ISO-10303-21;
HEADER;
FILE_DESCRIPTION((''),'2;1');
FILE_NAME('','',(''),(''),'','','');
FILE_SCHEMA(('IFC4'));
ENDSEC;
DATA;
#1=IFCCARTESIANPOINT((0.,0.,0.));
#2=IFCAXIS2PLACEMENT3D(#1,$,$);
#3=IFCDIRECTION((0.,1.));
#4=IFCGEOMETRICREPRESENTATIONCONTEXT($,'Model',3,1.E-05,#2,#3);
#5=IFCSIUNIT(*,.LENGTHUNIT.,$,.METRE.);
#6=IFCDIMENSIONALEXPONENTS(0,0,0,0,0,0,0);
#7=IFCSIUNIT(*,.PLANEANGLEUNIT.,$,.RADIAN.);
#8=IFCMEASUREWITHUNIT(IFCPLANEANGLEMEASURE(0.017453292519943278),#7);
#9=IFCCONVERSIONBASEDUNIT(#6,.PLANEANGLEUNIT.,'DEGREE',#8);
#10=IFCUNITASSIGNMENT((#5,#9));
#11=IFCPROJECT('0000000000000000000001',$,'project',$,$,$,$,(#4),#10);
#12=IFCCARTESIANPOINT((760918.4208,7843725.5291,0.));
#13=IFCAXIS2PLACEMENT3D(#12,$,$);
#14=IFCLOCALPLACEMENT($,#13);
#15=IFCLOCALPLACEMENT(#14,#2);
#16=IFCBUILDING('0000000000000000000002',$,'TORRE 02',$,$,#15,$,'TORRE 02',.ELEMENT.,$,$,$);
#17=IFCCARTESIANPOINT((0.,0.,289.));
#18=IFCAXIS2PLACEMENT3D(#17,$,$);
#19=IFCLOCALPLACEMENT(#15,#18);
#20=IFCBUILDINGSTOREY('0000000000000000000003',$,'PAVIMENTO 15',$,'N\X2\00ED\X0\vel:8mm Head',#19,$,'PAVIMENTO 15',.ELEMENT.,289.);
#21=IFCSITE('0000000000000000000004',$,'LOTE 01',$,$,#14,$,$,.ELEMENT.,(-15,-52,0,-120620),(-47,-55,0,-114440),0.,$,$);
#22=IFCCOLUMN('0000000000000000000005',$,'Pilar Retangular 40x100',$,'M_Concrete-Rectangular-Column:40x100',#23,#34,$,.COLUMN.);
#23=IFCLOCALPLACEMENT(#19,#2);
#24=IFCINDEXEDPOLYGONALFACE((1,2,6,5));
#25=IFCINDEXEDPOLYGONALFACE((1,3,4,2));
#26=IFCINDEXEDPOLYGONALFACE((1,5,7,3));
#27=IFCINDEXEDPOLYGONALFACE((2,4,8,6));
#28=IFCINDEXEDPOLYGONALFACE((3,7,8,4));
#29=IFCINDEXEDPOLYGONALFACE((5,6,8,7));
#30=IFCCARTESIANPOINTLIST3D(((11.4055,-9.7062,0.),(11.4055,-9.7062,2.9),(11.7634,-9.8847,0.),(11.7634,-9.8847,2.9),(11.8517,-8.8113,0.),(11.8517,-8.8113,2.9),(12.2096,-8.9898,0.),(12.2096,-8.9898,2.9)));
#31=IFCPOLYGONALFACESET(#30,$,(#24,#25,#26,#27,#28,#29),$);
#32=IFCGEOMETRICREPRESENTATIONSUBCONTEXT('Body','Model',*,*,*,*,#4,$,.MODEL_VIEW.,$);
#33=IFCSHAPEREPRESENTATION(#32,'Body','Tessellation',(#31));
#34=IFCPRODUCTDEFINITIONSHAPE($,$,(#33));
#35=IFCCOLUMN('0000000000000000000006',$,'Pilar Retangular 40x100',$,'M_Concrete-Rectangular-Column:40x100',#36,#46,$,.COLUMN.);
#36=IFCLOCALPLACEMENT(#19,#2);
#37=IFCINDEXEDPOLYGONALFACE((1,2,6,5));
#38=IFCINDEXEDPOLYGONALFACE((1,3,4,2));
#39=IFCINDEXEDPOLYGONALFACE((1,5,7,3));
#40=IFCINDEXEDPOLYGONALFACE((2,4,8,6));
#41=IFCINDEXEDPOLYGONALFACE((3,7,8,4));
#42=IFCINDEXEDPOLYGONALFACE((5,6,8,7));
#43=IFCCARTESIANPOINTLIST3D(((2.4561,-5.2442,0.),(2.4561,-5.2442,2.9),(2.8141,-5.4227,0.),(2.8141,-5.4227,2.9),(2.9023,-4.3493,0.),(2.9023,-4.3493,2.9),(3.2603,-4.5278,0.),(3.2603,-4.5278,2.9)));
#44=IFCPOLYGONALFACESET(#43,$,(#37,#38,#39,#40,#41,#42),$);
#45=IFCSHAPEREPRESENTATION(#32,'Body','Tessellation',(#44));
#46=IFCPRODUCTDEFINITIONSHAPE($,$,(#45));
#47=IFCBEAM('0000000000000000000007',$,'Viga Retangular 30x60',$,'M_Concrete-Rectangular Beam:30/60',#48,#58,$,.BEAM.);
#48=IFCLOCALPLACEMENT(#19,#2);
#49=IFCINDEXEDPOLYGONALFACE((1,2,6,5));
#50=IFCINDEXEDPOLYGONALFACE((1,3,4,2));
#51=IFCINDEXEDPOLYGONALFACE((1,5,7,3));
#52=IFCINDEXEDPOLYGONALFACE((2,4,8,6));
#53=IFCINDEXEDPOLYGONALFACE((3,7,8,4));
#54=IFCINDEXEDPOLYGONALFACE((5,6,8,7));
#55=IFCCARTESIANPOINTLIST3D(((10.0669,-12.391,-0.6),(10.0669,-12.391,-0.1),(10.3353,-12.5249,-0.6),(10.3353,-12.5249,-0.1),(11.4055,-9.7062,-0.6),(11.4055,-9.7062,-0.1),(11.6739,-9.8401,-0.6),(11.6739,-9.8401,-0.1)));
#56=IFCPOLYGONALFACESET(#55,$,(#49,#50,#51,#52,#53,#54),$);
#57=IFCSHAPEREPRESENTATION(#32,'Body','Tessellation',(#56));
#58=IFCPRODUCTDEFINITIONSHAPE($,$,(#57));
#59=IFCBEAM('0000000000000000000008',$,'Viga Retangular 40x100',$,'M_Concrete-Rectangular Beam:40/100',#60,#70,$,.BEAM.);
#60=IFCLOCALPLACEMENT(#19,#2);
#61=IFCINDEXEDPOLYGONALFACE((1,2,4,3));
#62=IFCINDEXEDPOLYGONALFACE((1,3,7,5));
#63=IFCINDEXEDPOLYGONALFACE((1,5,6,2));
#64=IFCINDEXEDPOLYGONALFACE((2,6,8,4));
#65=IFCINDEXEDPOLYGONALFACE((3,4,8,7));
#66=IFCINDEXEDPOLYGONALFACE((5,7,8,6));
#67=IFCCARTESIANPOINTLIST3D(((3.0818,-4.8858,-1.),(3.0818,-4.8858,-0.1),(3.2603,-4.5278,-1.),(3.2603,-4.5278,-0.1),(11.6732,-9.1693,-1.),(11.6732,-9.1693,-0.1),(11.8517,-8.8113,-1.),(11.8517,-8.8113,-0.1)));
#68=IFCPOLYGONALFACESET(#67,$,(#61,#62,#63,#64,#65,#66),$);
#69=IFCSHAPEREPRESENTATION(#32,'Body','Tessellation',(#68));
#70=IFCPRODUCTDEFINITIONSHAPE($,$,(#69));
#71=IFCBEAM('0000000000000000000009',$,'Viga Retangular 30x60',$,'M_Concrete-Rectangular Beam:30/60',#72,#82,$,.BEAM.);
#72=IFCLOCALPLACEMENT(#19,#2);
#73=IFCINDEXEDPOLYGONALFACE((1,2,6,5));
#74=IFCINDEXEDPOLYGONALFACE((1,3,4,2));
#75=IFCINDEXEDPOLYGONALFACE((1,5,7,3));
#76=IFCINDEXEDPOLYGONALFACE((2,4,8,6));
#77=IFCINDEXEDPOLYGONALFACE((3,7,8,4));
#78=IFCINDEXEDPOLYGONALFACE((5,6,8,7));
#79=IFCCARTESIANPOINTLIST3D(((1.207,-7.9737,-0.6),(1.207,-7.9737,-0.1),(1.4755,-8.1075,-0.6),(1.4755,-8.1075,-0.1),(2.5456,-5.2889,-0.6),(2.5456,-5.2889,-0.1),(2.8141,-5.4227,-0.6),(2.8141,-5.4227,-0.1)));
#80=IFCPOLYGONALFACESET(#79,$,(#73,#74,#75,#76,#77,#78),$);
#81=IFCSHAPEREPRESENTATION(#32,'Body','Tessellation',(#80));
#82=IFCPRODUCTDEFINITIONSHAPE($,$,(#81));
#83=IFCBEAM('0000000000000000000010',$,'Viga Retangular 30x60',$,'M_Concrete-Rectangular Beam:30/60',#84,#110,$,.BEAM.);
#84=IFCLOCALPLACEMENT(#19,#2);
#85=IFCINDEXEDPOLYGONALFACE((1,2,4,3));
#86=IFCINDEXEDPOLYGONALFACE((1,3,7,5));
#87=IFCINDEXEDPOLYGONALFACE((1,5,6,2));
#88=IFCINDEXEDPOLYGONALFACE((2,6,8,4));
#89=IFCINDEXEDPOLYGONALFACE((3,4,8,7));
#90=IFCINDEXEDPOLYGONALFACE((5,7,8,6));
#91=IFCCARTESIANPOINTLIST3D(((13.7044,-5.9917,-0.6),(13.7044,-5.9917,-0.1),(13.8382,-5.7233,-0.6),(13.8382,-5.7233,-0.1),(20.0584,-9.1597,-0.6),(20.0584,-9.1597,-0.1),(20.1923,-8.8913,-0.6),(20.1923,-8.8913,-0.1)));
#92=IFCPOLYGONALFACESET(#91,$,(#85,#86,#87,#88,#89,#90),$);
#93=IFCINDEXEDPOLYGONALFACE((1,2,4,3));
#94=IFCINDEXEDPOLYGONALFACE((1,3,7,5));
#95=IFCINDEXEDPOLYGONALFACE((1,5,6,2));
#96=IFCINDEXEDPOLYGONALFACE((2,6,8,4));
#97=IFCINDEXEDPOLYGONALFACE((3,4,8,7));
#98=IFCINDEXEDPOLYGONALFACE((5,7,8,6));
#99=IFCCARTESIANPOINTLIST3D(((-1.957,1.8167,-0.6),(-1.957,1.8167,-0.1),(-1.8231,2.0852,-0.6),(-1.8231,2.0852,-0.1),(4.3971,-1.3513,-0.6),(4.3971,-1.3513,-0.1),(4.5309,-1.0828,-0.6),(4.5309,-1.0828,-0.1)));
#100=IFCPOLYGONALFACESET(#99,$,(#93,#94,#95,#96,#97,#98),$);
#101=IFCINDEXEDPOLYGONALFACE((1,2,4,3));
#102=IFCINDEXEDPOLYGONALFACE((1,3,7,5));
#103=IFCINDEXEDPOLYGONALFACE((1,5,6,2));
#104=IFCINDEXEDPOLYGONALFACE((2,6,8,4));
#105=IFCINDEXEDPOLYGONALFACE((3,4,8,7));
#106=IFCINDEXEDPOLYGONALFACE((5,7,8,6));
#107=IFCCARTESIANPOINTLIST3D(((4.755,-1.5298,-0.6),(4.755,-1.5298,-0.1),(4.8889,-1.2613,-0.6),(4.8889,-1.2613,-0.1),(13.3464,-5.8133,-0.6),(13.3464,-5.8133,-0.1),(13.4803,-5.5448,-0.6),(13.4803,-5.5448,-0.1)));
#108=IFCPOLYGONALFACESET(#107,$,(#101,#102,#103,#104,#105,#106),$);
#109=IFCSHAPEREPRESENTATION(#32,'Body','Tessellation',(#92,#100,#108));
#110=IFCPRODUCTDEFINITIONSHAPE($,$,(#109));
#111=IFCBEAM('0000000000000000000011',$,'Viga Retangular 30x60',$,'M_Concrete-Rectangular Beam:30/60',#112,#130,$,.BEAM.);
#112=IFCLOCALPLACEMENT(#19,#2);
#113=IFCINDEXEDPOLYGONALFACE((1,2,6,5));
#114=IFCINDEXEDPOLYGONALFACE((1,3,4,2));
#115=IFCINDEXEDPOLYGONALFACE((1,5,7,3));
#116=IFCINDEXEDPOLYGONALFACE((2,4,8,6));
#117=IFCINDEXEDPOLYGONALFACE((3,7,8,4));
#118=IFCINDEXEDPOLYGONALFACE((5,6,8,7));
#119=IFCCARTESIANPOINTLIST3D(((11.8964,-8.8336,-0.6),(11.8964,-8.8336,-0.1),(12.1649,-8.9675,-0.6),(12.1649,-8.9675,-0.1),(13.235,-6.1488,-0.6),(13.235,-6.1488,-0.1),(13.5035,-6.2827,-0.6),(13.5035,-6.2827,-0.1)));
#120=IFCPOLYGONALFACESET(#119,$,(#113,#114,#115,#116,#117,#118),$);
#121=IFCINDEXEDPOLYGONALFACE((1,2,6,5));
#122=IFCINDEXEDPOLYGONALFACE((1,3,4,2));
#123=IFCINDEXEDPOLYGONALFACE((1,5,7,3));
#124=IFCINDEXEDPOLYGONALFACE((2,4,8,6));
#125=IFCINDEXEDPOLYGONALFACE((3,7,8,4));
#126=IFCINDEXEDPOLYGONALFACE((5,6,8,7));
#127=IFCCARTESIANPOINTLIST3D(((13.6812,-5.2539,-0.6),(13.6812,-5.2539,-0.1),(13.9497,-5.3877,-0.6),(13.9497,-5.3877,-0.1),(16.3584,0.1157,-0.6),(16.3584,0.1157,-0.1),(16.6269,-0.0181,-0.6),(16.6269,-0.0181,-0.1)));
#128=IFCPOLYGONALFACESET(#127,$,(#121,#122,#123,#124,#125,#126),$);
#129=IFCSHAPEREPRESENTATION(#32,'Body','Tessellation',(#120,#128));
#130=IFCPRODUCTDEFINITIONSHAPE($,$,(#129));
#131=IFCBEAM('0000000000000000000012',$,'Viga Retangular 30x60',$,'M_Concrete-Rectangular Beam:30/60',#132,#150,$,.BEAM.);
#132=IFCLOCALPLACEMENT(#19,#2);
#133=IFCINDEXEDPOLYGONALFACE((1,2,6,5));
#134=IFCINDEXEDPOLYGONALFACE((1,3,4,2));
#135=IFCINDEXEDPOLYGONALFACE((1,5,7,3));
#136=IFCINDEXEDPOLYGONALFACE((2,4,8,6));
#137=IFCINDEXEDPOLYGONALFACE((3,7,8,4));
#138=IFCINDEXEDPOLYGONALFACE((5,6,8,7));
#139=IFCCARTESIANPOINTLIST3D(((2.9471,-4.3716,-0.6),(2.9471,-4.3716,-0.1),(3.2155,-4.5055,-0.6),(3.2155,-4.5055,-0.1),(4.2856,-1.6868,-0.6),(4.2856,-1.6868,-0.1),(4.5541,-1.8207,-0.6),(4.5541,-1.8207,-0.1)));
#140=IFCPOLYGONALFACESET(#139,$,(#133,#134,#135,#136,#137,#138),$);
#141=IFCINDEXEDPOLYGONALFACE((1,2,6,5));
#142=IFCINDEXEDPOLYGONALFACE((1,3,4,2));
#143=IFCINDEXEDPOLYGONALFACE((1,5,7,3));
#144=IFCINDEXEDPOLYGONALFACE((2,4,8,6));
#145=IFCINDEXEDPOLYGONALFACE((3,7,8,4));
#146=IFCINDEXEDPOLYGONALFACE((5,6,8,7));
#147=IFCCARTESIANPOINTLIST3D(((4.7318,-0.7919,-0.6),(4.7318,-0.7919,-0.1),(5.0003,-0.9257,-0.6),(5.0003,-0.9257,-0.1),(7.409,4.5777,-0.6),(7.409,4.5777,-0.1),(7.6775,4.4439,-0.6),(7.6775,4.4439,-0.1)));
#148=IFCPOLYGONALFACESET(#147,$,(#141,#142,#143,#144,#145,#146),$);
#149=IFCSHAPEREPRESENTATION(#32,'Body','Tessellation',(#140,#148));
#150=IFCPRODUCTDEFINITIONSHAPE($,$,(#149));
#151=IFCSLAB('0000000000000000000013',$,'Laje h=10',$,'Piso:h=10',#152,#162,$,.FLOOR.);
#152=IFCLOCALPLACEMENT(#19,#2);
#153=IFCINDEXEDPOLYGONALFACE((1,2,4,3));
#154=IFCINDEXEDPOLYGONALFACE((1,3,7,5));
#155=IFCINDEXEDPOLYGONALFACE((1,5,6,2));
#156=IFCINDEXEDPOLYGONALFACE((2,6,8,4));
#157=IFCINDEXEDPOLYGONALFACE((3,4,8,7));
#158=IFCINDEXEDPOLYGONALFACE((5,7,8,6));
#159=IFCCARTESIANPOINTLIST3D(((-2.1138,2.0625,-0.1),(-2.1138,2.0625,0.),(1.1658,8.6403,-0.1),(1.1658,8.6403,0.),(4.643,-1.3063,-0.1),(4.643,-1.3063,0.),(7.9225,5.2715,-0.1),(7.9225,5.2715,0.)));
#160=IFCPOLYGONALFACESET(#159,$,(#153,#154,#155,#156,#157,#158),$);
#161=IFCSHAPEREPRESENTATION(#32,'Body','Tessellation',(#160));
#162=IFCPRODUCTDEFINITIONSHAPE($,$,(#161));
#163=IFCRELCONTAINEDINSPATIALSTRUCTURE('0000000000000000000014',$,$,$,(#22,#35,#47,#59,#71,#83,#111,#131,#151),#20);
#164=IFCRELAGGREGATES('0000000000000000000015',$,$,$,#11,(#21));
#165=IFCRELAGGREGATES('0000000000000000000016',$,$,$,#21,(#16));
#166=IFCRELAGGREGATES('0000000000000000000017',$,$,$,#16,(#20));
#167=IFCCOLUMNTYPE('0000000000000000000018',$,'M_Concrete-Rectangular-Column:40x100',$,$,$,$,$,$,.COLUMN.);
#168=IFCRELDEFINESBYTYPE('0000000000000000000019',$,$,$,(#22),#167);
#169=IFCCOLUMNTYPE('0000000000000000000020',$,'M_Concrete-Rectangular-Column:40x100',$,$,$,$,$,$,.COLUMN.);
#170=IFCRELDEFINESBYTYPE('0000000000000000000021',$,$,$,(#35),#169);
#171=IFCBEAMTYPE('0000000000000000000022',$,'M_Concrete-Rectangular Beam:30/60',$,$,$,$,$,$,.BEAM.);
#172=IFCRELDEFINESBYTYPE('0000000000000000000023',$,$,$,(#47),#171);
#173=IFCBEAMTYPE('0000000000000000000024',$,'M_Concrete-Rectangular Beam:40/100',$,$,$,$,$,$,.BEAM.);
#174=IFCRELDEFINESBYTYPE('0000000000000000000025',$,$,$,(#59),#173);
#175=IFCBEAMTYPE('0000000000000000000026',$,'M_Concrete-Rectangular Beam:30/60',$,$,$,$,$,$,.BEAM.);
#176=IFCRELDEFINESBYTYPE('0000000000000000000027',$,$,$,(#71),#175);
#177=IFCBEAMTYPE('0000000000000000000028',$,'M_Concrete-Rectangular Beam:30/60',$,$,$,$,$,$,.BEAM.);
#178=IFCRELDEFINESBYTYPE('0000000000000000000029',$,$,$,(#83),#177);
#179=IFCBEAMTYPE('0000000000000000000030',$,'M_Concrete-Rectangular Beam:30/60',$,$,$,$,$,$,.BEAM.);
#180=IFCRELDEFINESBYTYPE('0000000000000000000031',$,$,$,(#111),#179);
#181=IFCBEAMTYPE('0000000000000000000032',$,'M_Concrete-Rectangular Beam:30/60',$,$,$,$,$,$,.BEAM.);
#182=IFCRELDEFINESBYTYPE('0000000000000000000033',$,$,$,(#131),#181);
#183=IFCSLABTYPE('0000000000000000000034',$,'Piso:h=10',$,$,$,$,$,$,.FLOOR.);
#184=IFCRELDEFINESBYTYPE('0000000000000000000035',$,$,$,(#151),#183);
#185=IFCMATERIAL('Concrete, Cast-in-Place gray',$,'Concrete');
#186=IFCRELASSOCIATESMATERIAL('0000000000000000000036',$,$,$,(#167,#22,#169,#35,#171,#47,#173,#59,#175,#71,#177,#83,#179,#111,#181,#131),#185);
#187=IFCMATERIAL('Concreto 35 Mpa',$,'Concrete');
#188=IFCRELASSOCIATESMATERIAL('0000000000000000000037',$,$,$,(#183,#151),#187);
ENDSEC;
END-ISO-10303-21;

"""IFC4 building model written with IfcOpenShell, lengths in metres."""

from ifc_helpers import new_model, entity, si_unit, converted_unit, direction, frame, origin, place, context, subcontext, project, spatial, indexed_curve, outline, extrude, source, transform, mapped, material, type_object, type_shapes, element, save


model = new_model("IFC4")

# Units and contexts
model_context = context("Model", 3, precision=1e-05, world=origin(), true_north=direction((0.0, 1.0)))
body_context = subcontext(model_context, "Body", "Model", "MODEL_VIEW")
ifc_project = project(units=[si_unit("LENGTHUNIT", "METRE"), converted_unit("PLANEANGLEUNIT", "DEGREE", entity("IfcPlaneAngleMeasure", 0.017453292519943278), si_unit("PLANEANGLEUNIT", "RADIAN"), dimensions=[0, 0, 0, 0, 0, 0, 0])], contexts=[model_context])

# Site, building, storey
site_placement = place(None, frame((760918.4208, 7843725.5291, 0.0)))
site = spatial("IfcSite", under=ifc_project, at=site_placement, Name="LOTE 01", CompositionType="ELEMENT", RefLatitude=(-15, -52, 0, -120620), RefLongitude=(-47, -55, 0, -114440), RefElevation=0.0)
building_placement = place(site_placement, origin())
building = spatial("IfcBuilding", under=site, at=building_placement, Name="TORRE 02", LongName="TORRE 02", CompositionType="ELEMENT")
storey_placement = place(building_placement, frame((0.0, 0.0, 289.0)))
storey = spatial("IfcBuildingStorey", under=building, at=storey_placement, Name="PAVIMENTO 15", ObjectType="Nível:8mm Head", LongName="PAVIMENTO 15", CompositionType="ELEMENT", Elevation=289.0)

# Columns
ifc_material_1 = material(Name="Concrete, Cast-in-Place gray", Category="Concrete")
column_type_1 = type_object("IfcColumnType", Name="M_Concrete-Rectangular-Column:40x100", PredefinedType="COLUMN", material=ifc_material_1)
shared_shape_1 = source(origin(), body_context, "Body", "SweptSolid", [
    extrude(outline(indexed_curve([(-1.45, -0.2), (1.45, -0.2), (1.45, 0.2), (-1.45, 0.2), (-1.45, -0.2)], self_intersect=False)), frame((11.5844, -9.7955, 290.45), z_axis=(0.446198, 0.894934, 0.0), x_axis=(0.0, 0.0, 1.0)), (0.0, 0.0, 1.0), 1.0),
])
type_shapes(column_type_1, [shared_shape_1])
column_1_placement = place(storey_placement, frame((0.0, 0.0, -289.0)))
element("IfcColumn", 1, at=column_1_placement, inside=storey, type_object=column_type_1, material=ifc_material_1, Name="Pilar Retangular 40x100", ObjectType="M_Concrete-Rectangular-Column:40x100", PredefinedType="COLUMN", context=body_context, shape_type="MappedRepresentation", body=[
    mapped(shared_shape_1, transform((0.0, 0.0, 0.0), scale=1.0)),
])
column_type_2 = type_object("IfcColumnType", Name="M_Concrete-Rectangular-Column:40x100", PredefinedType="COLUMN", material=ifc_material_1)
shared_shape_2 = source(origin(), body_context, "Body", "SweptSolid", [
    extrude(outline(indexed_curve([(-1.45, -0.2), (1.45, -0.2), (1.45, 0.2), (-1.45, 0.2), (-1.45, -0.2)], self_intersect=False)), frame((2.6351, -5.3335, 290.45), z_axis=(0.446198, 0.894934, 0.0), x_axis=(0.0, 0.0, 1.0)), (0.0, 0.0, 1.0), 1.0),
])
type_shapes(column_type_2, [shared_shape_2])
column_2_placement = place(storey_placement, frame((0.0, 0.0, -289.0)))
element("IfcColumn", 2, at=column_2_placement, inside=storey, type_object=column_type_2, material=ifc_material_1, Name="Pilar Retangular 40x100", ObjectType="M_Concrete-Rectangular-Column:40x100", PredefinedType="COLUMN", context=body_context, shape_type="MappedRepresentation", body=[
    mapped(shared_shape_2, transform((0.0, 0.0, 0.0), scale=1.0)),
])

# Beams
beam_type_1 = type_object("IfcBeamType", Name="M_Concrete-Rectangular Beam:30/60", PredefinedType="BEAM", material=ifc_material_1)
shared_shape_3 = source(origin(), body_context, "Body", "SweptSolid", [
    extrude(outline(indexed_curve([(-0.25, -0.15), (0.25, -0.15), (0.25, 0.15), (-0.25, 0.15), (-0.25, -0.15)], self_intersect=False)), frame((10.2011, -12.458, 288.65), z_axis=(0.446198, 0.894934, 0.0), x_axis=(0.0, 0.0, 1.0)), (0.0, 0.0, 1.0), 3.0),
])
type_shapes(beam_type_1, [shared_shape_3])
beam_1_placement = place(storey_placement, frame((0.0, 0.0, -289.0)))
element("IfcBeam", 3, at=beam_1_placement, inside=storey, type_object=beam_type_1, material=ifc_material_1, Name="Viga Retangular 30x60", ObjectType="M_Concrete-Rectangular Beam:30/60", PredefinedType="BEAM", context=body_context, shape_type="MappedRepresentation", body=[
    mapped(shared_shape_3, transform((0.0, 0.0, 0.0), scale=1.0)),
])
beam_type_2 = type_object("IfcBeamType", Name="M_Concrete-Rectangular Beam:40/100", PredefinedType="BEAM", material=ifc_material_1)
shared_shape_4 = source(origin(), body_context, "Body", "SweptSolid", [
    extrude(outline(indexed_curve([(-0.45, -0.2), (0.45, -0.2), (0.45, 0.2), (-0.45, 0.2), (-0.45, -0.2)], self_intersect=False)), frame((11.7624, -8.9903, 288.45), z_axis=(-0.894934, 0.446198, 0.0), x_axis=(0.0, 0.0, 1.0)), (0.0, 0.0, 1.0), 9.6),
])
type_shapes(beam_type_2, [shared_shape_4])
beam_2_placement = place(storey_placement, frame((0.0, 0.0, -289.0)))
element("IfcBeam", 4, at=beam_2_placement, inside=storey, type_object=beam_type_2, material=ifc_material_1, Name="Viga Retangular 40x100", ObjectType="M_Concrete-Rectangular Beam:40/100", PredefinedType="BEAM", context=body_context, shape_type="MappedRepresentation", body=[
    mapped(shared_shape_4, transform((0.0, 0.0, 0.0), scale=1.0)),
])
beam_type_3 = type_object("IfcBeamType", Name="M_Concrete-Rectangular Beam:30/60", PredefinedType="BEAM", material=ifc_material_1)
shared_shape_5 = source(origin(), body_context, "Body", "SweptSolid", [
    extrude(outline(indexed_curve([(-0.25, -0.15), (0.25, -0.15), (0.25, 0.15), (-0.25, 0.15), (-0.25, -0.15)], self_intersect=False)), frame((2.6798, -5.3558, 288.65), z_axis=(-0.446198, -0.894934, 0.0), x_axis=(0.0, 0.0, -1.0)), (0.0, 0.0, 1.0), 3.0),
])
type_shapes(beam_type_3, [shared_shape_5])
beam_3_placement = place(storey_placement, frame((0.0, 0.0, -289.0)))
element("IfcBeam", 5, at=beam_3_placement, inside=storey, type_object=beam_type_3, material=ifc_material_1, Name="Viga Retangular 30x60", ObjectType="M_Concrete-Rectangular Beam:30/60", PredefinedType="BEAM", context=body_context, shape_type="MappedRepresentation", body=[
    mapped(shared_shape_5, transform((0.0, 0.0, 0.0), scale=1.0)),
])
beam_type_4 = type_object("IfcBeamType", Name="M_Concrete-Rectangular Beam:30/60", PredefinedType="BEAM", material=ifc_material_1)
shared_shape_6 = source(origin(), body_context, "Body", "SweptSolid", [
    extrude(outline(indexed_curve([(-0.25, -0.15), (0.25, -0.15), (0.25, 0.15), (-0.25, 0.15), (-0.25, -0.15)], self_intersect=False)), frame((13.7713, -5.8575, 288.65), z_axis=(0.894934, -0.446198, 0.0), x_axis=(0.0, 0.0, -1.0)), (0.0, 0.0, 1.0), 7.1),
    extrude(outline(indexed_curve([(-0.25, -0.15), (0.25, -0.15), (0.25, 0.15), (-0.25, 0.15), (-0.25, -0.15)], self_intersect=False)), frame((-1.89, 1.951, 288.65), z_axis=(0.894934, -0.446198, 0.0), x_axis=(0.0, 0.0, -1.0)), (0.0, 0.0, 1.0), 7.1),
    extrude(outline(indexed_curve([(-0.25, -0.15), (0.25, -0.15), (0.25, 0.15), (-0.25, 0.15), (-0.25, -0.15)], self_intersect=False)), frame((4.822, -1.3955, 288.65), z_axis=(0.894934, -0.446198, 0.0), x_axis=(0.0, 0.0, -1.0)), (0.0, 0.0, 1.0), 9.6),
])
type_shapes(beam_type_4, [shared_shape_6])
beam_4_placement = place(storey_placement, frame((0.0, 0.0, -289.0)))
element("IfcBeam", 6, at=beam_4_placement, inside=storey, type_object=beam_type_4, material=ifc_material_1, Name="Viga Retangular 30x60", ObjectType="M_Concrete-Rectangular Beam:30/60", PredefinedType="BEAM", context=body_context, shape_type="MappedRepresentation", body=[
    mapped(shared_shape_6, transform((0.0, 0.0, 0.0), scale=1.0)),
])
beam_type_5 = type_object("IfcBeamType", Name="M_Concrete-Rectangular Beam:30/60", PredefinedType="BEAM", material=ifc_material_1)
shared_shape_7 = source(origin(), body_context, "Body", "SweptSolid", [
    extrude(outline(indexed_curve([(-0.25, -0.15), (0.25, -0.15), (0.25, 0.15), (-0.25, 0.15), (-0.25, -0.15)], self_intersect=False)), frame((12.0306, -8.9005, 288.65), z_axis=(0.446198, 0.894934, 0.0), x_axis=(0.0, 0.0, 1.0)), (0.0, 0.0, 1.0), 3.0),
    extrude(outline(indexed_curve([(-0.25, -0.15), (0.25, -0.15), (0.25, 0.15), (-0.25, 0.15), (-0.25, -0.15)], self_intersect=False)), frame((13.8154, -5.3208, 288.65), z_axis=(0.446198, 0.894934, 0.0), x_axis=(0.0, 0.0, 1.0)), (0.0, 0.0, 1.0), 6.0),
])
type_shapes(beam_type_5, [shared_shape_7])
beam_5_placement = place(storey_placement, frame((0.0, 0.0, -289.0)))
element("IfcBeam", 7, at=beam_5_placement, inside=storey, type_object=beam_type_5, material=ifc_material_1, Name="Viga Retangular 30x60", ObjectType="M_Concrete-Rectangular Beam:30/60", PredefinedType="BEAM", context=body_context, shape_type="MappedRepresentation", body=[
    mapped(shared_shape_7, transform((0.0, 0.0, 0.0), scale=1.0)),
])
beam_type_6 = type_object("IfcBeamType", Name="M_Concrete-Rectangular Beam:30/60", PredefinedType="BEAM", material=ifc_material_1)
shared_shape_8 = source(origin(), body_context, "Body", "SweptSolid", [
    extrude(outline(indexed_curve([(-0.25, -0.15), (0.25, -0.15), (0.25, 0.15), (-0.25, 0.15), (-0.25, -0.15)], self_intersect=False)), frame((3.0813, -4.4385, 288.65), z_axis=(0.446198, 0.894934, 0.0), x_axis=(0.0, 0.0, 1.0)), (0.0, 0.0, 1.0), 3.0),
    extrude(outline(indexed_curve([(-0.25, -0.15), (0.25, -0.15), (0.25, 0.15), (-0.25, 0.15), (-0.25, -0.15)], self_intersect=False)), frame((4.8661, -0.8588, 288.65), z_axis=(0.446198, 0.894934, 0.0), x_axis=(0.0, 0.0, 1.0)), (0.0, 0.0, 1.0), 6.0),
])
type_shapes(beam_type_6, [shared_shape_8])
beam_6_placement = place(storey_placement, frame((0.0, 0.0, -289.0)))
element("IfcBeam", 8, at=beam_6_placement, inside=storey, type_object=beam_type_6, material=ifc_material_1, Name="Viga Retangular 30x60", ObjectType="M_Concrete-Rectangular Beam:30/60", PredefinedType="BEAM", context=body_context, shape_type="MappedRepresentation", body=[
    mapped(shared_shape_8, transform((0.0, 0.0, 0.0), scale=1.0)),
])

# Slab
ifc_material_2 = material(Name="Concreto 35 Mpa", Category="Concrete")
slab_type = type_object("IfcSlabType", Name="Piso:h=10", PredefinedType="FLOOR", material=ifc_material_2)
slab_1_placement = place(storey_placement, origin())
element("IfcSlab", 9, at=slab_1_placement, inside=storey, type_object=slab_type, material=ifc_material_2, Name="Laje h=10", ObjectType="Piso:h=10", PredefinedType="FLOOR", context=body_context, shape_type="SweptSolid", body=[
    extrude(outline(indexed_curve([(-3.675, -3.775), (3.675, -3.775), (3.675, 3.775), (-3.675, 3.775), (-3.675, -3.775)], self_intersect=False)), frame((2.9044, 3.667, 0.0), z_axis=(0.0, 0.0, -1.0), x_axis=(-0.446198, -0.894934, 0.0)), (0.0, 0.0, 1.0), 0.1),
])

save(model, "model.ifc")
